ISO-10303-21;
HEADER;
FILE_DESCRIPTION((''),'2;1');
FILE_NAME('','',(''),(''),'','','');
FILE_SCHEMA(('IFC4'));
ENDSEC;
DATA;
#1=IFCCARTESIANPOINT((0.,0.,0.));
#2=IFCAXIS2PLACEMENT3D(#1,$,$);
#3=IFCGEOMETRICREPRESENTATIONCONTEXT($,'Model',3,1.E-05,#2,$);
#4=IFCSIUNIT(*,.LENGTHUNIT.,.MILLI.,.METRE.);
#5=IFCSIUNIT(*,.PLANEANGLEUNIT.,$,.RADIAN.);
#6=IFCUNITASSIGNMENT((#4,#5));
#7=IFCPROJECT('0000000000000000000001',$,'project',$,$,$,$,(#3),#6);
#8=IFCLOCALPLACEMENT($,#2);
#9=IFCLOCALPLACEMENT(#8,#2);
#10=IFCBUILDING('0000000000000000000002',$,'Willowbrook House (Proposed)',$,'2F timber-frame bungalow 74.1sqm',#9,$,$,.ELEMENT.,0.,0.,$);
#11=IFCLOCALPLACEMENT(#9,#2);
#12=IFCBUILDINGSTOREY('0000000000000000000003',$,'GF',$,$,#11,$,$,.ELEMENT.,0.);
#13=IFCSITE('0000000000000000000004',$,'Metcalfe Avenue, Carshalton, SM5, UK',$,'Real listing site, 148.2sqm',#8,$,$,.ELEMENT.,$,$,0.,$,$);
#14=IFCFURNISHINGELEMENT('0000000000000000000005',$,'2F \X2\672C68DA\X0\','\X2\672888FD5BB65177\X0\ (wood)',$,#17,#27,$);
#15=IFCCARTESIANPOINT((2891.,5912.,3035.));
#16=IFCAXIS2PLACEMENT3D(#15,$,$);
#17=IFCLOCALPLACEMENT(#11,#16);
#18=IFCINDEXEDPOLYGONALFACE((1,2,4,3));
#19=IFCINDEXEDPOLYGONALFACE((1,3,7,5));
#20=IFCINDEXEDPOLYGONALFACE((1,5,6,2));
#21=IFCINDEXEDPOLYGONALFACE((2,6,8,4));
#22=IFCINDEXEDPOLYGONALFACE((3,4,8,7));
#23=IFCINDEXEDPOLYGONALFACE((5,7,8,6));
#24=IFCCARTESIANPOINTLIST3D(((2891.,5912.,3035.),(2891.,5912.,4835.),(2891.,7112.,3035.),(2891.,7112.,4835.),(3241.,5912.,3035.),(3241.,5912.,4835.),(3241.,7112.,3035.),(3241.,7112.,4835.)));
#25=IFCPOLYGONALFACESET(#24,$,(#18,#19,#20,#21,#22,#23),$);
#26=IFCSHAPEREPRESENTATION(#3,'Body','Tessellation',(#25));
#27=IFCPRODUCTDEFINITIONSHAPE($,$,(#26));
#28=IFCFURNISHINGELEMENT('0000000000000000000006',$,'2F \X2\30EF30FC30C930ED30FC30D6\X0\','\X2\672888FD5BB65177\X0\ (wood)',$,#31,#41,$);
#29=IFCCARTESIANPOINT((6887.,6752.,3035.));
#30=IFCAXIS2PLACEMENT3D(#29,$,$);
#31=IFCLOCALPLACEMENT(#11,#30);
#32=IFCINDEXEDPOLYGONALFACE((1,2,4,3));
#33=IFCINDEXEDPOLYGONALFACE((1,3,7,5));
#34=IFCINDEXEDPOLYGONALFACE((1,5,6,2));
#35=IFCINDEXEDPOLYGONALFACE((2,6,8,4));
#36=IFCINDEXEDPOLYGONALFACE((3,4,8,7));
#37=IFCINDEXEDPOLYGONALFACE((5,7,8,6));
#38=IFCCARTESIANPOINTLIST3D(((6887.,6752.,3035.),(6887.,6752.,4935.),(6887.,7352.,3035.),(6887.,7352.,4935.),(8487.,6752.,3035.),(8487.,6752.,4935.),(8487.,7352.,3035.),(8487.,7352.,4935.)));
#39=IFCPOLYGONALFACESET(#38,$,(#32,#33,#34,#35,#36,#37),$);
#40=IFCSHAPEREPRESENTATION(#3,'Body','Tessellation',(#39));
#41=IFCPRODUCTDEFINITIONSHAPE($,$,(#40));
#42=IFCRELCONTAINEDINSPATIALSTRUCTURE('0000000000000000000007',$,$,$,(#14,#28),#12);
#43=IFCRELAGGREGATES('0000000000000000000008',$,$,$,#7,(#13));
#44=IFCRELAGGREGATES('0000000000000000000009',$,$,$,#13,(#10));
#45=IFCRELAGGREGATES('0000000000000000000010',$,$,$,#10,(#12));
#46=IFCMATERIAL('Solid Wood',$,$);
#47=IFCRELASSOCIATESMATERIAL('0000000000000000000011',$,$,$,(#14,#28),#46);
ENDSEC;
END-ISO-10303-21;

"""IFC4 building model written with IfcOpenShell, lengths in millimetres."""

from ifc_helpers import new_model, si_unit, frame, frame_2d, origin, place, context, project, spatial, rectangle, extrude, material, element, save


model = new_model("IFC4")

# Units and contexts
model_context = context("Model", 3, precision=1e-05, world=origin())
ifc_project = project(units=[si_unit("LENGTHUNIT", "METRE", prefix="MILLI"), si_unit("PLANEANGLEUNIT", "RADIAN")], contexts=[model_context])

# Site, building, storey
site_placement = place(None, origin())
site = spatial("IfcSite", under=ifc_project, at=site_placement, Name="Metcalfe Avenue, Carshalton, SM5, UK", ObjectType="Real listing site, 148.2sqm", CompositionType="ELEMENT", RefElevation=0.0)
building_placement = place(site_placement, origin())
building = spatial("IfcBuilding", under=site, at=building_placement, Name="Willowbrook House (Proposed)", ObjectType="2F timber-frame bungalow 74.1sqm", CompositionType="ELEMENT", ElevationOfRefHeight=0.0, ElevationOfTerrain=0.0)
storey_placement = place(building_placement, origin())
storey = spatial("IfcBuildingStorey", under=building, at=storey_placement, Name="GF", CompositionType="ELEMENT", Elevation=0.0)

# Shared definitions
ifc_material_1 = material(Name="Solid Wood")

# Furnishing elements
furnishing_1_placement = place(storey_placement, frame((2891.0, 5912.0, 3035.0)))
element("IfcFurnishingElement", 1, at=furnishing_1_placement, inside=storey, material=ifc_material_1, Name="2F 本棚", Description="木製家具 (wood)", context=model_context, shape_type="SweptSolid", body=[
    extrude(rectangle(XDim=350.0, YDim=1200.0, at=frame_2d((175.0, 600.0))), frame((2891.0, 5912.0, 3035.0)), (0.0, 0.0, 1.0), 1800.0),
])
furnishing_2_placement = place(storey_placement, frame((6887.0, 6752.0, 3035.0)))
element("IfcFurnishingElement", 2, at=furnishing_2_placement, inside=storey, material=ifc_material_1, Name="2F ワードローブ", Description="木製家具 (wood)", context=model_context, shape_type="SweptSolid", body=[
    extrude(rectangle(XDim=1600.0, YDim=600.0, at=frame_2d((800.0, 300.0))), frame((6887.0, 6752.0, 3035.0)), (0.0, 0.0, 1.0), 1900.0),
])

save(model, "model.ifc")
